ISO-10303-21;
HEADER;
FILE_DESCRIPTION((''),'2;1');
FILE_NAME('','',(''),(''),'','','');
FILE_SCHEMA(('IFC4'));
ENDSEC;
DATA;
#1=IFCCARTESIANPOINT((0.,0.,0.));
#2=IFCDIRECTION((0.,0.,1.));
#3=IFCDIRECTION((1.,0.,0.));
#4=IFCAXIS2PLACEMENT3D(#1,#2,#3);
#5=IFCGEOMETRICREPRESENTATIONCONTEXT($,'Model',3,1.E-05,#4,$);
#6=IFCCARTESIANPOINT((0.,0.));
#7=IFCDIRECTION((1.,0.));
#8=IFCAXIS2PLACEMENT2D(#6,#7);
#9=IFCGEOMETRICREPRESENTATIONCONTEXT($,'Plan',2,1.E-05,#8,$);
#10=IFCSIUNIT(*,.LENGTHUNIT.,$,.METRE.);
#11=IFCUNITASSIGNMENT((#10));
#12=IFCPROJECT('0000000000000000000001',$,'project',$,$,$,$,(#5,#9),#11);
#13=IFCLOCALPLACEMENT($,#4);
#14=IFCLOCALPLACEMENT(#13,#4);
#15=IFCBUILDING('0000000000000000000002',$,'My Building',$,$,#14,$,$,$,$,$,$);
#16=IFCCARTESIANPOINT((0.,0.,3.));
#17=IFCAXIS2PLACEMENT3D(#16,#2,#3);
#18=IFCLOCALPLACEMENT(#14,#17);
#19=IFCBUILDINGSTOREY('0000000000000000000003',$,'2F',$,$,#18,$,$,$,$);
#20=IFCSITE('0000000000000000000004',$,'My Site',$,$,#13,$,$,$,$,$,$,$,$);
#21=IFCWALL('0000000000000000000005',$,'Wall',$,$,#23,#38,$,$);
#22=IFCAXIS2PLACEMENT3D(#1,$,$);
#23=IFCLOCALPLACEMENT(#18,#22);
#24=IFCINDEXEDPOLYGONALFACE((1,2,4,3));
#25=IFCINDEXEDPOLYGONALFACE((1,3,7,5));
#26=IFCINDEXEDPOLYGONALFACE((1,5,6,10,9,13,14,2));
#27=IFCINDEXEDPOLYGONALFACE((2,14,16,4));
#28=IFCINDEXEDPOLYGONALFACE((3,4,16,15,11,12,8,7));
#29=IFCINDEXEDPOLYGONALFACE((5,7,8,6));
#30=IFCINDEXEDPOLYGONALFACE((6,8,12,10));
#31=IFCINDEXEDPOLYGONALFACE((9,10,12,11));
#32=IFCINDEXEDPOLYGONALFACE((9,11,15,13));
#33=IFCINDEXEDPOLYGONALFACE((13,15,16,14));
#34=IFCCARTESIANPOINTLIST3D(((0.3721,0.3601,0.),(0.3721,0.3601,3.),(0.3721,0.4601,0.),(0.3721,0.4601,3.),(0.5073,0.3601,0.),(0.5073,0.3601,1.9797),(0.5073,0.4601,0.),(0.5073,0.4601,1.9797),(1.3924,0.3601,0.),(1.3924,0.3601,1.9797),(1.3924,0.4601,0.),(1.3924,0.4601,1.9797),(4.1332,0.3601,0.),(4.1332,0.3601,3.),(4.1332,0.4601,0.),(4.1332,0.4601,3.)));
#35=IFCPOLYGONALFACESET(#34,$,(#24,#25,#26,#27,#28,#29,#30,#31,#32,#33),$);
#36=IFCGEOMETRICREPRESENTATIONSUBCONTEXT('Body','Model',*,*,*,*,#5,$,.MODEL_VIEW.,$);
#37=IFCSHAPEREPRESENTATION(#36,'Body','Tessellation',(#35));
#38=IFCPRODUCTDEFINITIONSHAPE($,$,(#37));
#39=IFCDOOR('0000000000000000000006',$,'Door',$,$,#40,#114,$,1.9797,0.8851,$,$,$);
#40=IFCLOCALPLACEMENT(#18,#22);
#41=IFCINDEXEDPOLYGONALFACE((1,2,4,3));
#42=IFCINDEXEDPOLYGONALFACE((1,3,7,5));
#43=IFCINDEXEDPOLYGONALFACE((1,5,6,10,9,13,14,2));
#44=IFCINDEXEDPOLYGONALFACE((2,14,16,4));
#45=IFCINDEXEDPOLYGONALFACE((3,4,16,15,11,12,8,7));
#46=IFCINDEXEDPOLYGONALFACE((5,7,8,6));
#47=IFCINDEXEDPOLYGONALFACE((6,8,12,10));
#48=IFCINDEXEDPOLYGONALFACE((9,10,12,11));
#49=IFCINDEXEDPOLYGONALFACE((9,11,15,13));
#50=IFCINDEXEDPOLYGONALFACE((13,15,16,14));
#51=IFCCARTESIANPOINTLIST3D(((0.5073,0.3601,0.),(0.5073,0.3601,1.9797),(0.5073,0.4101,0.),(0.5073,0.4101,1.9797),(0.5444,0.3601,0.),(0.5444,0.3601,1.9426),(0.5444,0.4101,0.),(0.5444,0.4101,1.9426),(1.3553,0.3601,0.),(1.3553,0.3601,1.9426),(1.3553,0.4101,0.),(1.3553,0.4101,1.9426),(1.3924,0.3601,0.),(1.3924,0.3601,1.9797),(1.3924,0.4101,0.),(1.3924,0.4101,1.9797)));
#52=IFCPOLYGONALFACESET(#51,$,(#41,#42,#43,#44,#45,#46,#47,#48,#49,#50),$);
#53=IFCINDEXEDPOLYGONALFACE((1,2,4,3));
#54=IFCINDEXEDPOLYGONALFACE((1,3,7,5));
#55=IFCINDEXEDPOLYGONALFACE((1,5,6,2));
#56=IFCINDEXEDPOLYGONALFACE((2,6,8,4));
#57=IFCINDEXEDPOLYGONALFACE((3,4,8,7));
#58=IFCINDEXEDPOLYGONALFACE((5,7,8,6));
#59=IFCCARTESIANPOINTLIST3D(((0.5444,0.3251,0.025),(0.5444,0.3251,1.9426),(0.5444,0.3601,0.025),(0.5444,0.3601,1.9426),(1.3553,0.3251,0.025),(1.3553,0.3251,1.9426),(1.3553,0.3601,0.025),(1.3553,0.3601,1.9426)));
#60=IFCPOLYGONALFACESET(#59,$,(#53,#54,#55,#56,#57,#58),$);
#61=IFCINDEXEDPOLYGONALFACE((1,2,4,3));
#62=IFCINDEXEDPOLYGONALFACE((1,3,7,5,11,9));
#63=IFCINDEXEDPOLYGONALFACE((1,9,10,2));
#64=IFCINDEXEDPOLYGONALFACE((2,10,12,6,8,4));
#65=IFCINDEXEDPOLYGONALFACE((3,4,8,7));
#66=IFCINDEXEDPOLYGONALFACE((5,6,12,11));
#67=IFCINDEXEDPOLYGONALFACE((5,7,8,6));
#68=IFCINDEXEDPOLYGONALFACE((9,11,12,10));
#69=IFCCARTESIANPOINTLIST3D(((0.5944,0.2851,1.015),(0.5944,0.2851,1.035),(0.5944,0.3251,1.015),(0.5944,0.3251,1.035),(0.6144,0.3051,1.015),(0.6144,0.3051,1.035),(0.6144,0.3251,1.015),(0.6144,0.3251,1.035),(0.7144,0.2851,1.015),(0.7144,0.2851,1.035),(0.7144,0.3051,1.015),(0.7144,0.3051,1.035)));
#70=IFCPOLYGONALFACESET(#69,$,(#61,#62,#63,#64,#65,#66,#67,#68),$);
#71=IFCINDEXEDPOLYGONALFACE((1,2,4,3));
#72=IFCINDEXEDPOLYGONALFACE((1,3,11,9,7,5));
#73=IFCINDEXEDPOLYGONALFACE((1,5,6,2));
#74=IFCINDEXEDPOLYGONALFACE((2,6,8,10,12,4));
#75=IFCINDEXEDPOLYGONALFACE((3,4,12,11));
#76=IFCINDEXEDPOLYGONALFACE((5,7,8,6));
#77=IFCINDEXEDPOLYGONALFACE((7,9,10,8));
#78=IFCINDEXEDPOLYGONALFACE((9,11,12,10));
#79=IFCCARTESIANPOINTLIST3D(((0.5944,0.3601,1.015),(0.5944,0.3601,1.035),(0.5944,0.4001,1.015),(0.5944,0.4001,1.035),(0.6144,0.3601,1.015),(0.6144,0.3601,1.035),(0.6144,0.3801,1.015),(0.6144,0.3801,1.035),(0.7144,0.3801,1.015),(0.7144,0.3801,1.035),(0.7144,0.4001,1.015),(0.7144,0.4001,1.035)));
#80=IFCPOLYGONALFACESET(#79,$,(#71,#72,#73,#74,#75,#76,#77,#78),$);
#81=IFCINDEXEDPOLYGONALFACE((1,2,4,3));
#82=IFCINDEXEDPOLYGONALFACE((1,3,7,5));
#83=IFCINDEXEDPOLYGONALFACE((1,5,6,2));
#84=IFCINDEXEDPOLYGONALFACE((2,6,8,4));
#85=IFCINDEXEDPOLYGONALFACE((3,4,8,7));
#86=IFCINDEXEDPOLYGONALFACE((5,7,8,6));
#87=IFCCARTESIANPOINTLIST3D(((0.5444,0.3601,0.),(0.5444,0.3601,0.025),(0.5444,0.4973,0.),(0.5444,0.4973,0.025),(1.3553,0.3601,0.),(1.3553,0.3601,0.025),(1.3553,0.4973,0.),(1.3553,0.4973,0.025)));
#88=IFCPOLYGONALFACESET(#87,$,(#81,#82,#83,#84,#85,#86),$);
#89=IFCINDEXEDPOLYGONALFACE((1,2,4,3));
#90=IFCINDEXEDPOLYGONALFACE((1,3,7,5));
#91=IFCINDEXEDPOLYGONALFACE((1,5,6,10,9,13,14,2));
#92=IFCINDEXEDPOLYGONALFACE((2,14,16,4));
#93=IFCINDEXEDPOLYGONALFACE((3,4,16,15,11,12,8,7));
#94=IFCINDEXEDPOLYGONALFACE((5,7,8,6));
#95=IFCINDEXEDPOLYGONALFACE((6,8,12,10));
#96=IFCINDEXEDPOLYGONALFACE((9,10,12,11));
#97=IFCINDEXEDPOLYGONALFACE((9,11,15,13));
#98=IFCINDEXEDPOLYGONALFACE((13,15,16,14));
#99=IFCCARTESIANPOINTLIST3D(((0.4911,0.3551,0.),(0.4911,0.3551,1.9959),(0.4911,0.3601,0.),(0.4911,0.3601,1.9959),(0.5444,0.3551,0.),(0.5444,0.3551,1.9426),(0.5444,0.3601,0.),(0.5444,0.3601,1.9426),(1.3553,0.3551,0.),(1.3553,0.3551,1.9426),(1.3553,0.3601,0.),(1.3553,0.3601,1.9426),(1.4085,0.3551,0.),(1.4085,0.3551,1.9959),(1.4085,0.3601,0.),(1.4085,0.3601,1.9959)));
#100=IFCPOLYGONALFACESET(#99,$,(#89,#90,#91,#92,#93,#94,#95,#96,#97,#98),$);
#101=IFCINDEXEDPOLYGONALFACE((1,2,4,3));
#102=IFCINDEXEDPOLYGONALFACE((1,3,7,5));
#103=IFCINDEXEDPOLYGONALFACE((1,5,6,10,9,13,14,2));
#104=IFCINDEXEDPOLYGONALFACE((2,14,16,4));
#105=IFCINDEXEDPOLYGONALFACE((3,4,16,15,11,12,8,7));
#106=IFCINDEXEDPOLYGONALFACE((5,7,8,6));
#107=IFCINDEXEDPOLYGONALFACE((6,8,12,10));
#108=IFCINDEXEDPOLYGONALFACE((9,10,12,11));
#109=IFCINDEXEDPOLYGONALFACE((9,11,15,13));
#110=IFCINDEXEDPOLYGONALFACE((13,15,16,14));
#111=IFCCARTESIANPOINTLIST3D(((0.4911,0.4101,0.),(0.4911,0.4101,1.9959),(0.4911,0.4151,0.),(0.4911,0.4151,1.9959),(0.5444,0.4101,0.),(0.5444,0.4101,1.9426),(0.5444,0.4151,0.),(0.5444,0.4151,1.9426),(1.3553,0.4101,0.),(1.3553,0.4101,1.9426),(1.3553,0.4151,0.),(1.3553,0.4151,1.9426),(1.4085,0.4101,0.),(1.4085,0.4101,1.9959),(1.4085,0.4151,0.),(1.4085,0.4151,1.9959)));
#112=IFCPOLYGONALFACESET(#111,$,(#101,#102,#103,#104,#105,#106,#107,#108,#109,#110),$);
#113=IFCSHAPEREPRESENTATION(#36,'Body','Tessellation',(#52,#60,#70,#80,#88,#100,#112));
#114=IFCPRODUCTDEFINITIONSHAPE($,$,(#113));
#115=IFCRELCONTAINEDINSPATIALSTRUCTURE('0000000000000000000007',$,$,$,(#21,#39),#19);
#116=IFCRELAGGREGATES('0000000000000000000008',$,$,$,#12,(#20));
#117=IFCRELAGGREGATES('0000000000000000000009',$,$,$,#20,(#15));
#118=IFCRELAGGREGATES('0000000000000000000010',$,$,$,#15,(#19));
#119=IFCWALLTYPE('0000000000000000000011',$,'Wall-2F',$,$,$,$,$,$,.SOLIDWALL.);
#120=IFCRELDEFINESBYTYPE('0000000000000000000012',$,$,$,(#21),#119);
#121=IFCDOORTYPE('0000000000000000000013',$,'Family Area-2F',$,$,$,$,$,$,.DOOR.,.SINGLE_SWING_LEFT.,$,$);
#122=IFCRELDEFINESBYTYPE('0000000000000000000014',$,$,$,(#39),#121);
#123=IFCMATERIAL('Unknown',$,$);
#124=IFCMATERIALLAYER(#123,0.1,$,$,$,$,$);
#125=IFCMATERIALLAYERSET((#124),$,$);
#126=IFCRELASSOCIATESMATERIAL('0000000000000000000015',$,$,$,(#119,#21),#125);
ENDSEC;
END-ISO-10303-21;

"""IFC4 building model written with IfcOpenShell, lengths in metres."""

from ifc_helpers import new_model, entity, si_unit, frame, origin_with_axes, origin_2d_with_axis, place, context, subcontext, project, spatial, line, indexed_curve, outline, extrude, shape, source, transform, mapped, material, layer, layer_set, layer_usage, type_object, type_shapes, element, fill, save


model = new_model("IFC4")

# Units and contexts
model_context = context("Model", 3, precision=1e-05, world=origin_with_axes())
plan_context = context("Plan", 2, precision=1e-05, world=origin_2d_with_axis())
body_context_1 = subcontext(model_context, "Body", "Model", "MODEL_VIEW")
body_context_2 = subcontext(plan_context, "Body", "Plan", "PLAN_VIEW")
ifc_project = project(units=[si_unit("LENGTHUNIT", "METRE")], contexts=[model_context, plan_context])

# Site, building, storey
site_placement = place(None, origin_with_axes())
site = spatial("IfcSite", under=ifc_project, at=site_placement, Name="My Site")
building_placement = place(site_placement, origin_with_axes())
building = spatial("IfcBuilding", under=site, at=building_placement, Name="My Building")
storey_placement = place(building_placement, frame((0.0, 0.0, 3.0), z_axis=(0.0, 0.0, 1.0), x_axis=(1.0, 0.0, 0.0)))
storey = spatial("IfcBuildingStorey", under=building, at=storey_placement, Name="2F")

# Shared definitions
ifc_material = material(Name="Unknown")

# Shared definitions
ifc_layer_1 = layer(ifc_material, 0.1)
ifc_layer_set_1 = layer_set([ifc_layer_1])
wall_type = type_object("IfcWallType", Name="Wall-2F", PredefinedType="SOLIDWALL", material=ifc_layer_set_1)

# Wall, opening, door
ifc_layer_usage_1 = layer_usage(ifc_layer_set_1, "AXIS2", "POSITIVE", 0.0)
wall_1_placement = place(storey_placement, frame((4.1332, 0.4601, 0.0), z_axis=(0.0, 0.0, 1.0), x_axis=(-1.0, 0.0, 0.0)))
wall_1 = element("IfcWall", 1, at=wall_1_placement, inside=storey, type_object=wall_type, material=ifc_layer_usage_1, Name="Wall", context=body_context_1, shape_type="SweptSolid", body=[
    extrude(outline(indexed_curve([(0.0, 0.0), (0.0, 0.1), (3.7611, 0.1), (3.7611, 0.0)], segments=[line(1, 2, 3, 4, 1)])), origin_with_axes(), (0.0, 0.0, 1.0), 3.0),
])
shared_shape_1 = source(origin_with_axes(), body_context_1, "Body", "SweptSolid", [
    extrude(outline(indexed_curve([(0.0, 0.0), (0.8851, 0.0), (0.8851, 1.9797), (0.0, 1.9797)], segments=[line(1, 2, 3, 4, 1)])), frame((0.0, -0.6, 0.0), z_axis=(0.0, -1.0, 0.0), x_axis=(1.0, 0.0, 0.0)), (0.0, 0.0, -1.0), 1.2),
])
opening_1_placement = place(wall_1_placement, frame((3.6259, 0.1, 0.0), z_axis=(0.0, 0.0, 1.0), x_axis=(-1.0, 0.0, 0.0)))
opening_1 = element("IfcOpeningElement", 2, at=opening_1_placement, cuts=wall_1, PredefinedType="OPENING", context=body_context_1, shape_type="MappedRepresentation", body=[
    mapped(shared_shape_1, transform((0.0, 0.0, 0.0), x_axis=(1.0, 0.0, 0.0), y_axis=(0.0, 1.0, 0.0), z_axis=(0.0, 0.0, 1.0), scale=1.0)),
])
door_type_1 = type_object("IfcDoorType", Name="Family Area-2F", OperationType="SINGLE_SWING_LEFT", PredefinedType="DOOR")
shared_shape_2 = source(origin_with_axes(), body_context_1, "Body", "SweptSolid", [
    extrude(outline(indexed_curve([(0.0, 0.0), (0.0, 1.9797), (0.8851, 1.9797), (0.8851, 0.0), (0.848, 0.0), (0.848, 1.9426), (0.0371, 1.9426), (0.0371, 0.0)], segments=[line(1, 2, 3, 4, 5, 6, 7, 8, 1)])), frame((0.0, 0.0, 0.0), z_axis=(0.0, -1.0, 0.0), x_axis=(1.0, 0.0, 0.0)), (0.0, 0.0, -1.0), 0.05),
    extrude(outline(indexed_curve([(0.0, 0.0), (0.8109, 0.0), (0.8109, 0.035), (0.0, 0.035)], segments=[line(1, 2, 3, 4, 1)])), frame((0.0371, -0.035, 0.025), z_axis=(0.0, 0.0, 1.0), x_axis=(1.0, 0.0, 0.0)), (0.0, 0.0, 1.0), 1.9176),
    extrude(outline(indexed_curve([(0.0, 0.0), (0.0, -0.04), (0.12, -0.04), (0.12, -0.02), (0.02, -0.02), (0.02, 0.0)], segments=[line(1, 2, 3, 4, 5, 6, 1)])), frame((0.0871, -0.035, 1.015), z_axis=(0.0, 0.0, 1.0), x_axis=(1.0, 0.0, 0.0)), (0.0, 0.0, 1.0), 0.02),
    extrude(outline(indexed_curve([(0.0, 0.0), (0.0, 0.04), (0.12, 0.04), (0.12, 0.02), (0.02, 0.02), (0.02, 0.0)], segments=[line(1, 2, 3, 4, 5, 6, 1)])), frame((0.0871, 0.0, 1.015), z_axis=(0.0, 0.0, 1.0), x_axis=(1.0, 0.0, 0.0)), (0.0, 0.0, 1.0), 0.02),
    extrude(outline(indexed_curve([(0.0, 0.0), (0.8109, 0.0), (0.8109, 0.1372), (0.0, 0.1372)], segments=[line(1, 2, 3, 4, 1)])), frame((0.0371, 0.0, 0.0), z_axis=(0.0, 0.0, 1.0), x_axis=(1.0, 0.0, 0.0)), (0.0, 0.0, 1.0), 0.025),
    extrude(outline(indexed_curve([(0.0, 0.0), (0.0, 1.9959), (0.9174, 1.9959), (0.9174, 0.0), (0.8641, 0.0), (0.8641, 1.9426), (0.0532, 1.9426), (0.0532, 0.0)], segments=[line(1, 2, 3, 4, 5, 6, 7, 8, 1)])), frame((-0.0162, -0.005, 0.0), z_axis=(0.0, -1.0, 0.0), x_axis=(1.0, 0.0, 0.0)), (0.0, 0.0, -1.0), 0.005),
    extrude(outline(indexed_curve([(0.0, 0.0), (0.0, 1.9959), (0.9174, 1.9959), (0.9174, 0.0), (0.8641, 0.0), (0.8641, 1.9426), (0.0532, 1.9426), (0.0532, 0.0)], segments=[line(1, 2, 3, 4, 5, 6, 7, 8, 1)])), frame((-0.0162, 0.05, 0.0), z_axis=(0.0, -1.0, 0.0), x_axis=(1.0, 0.0, 0.0)), (0.0, 0.0, -1.0), 0.005),
])
shared_shape_3 = source(origin_with_axes(), body_context_2, "Body", "Curve2D", [
    entity("IfcIndexedPolyCurve", entity("IfcCartesianPointList2D", [[0.0, 0.0], [0.0371, 0.0], [0.0371, 0.05], [0.0, 0.05]]), [entity("IfcLineIndex", [1, 2, 3, 4, 1])]),
    entity("IfcIndexedPolyCurve", entity("IfcCartesianPointList2D", [[0.8851, 0.0], [0.848, 0.0], [0.848, 0.05], [0.8851, 0.05]]), [entity("IfcLineIndex", [1, 2, 3, 4, 1])]),
    entity("IfcIndexedPolyCurve", entity("IfcCartesianPointList2D", [[1.2534, -0.035], [0.4425, -0.035], [0.4425, 0.0], [1.2534, 0.0]]), [entity("IfcLineIndex", [1, 2, 3, 4, 1])]),
])
type_shapes(door_type_1, [shared_shape_2, shared_shape_3])
door_1_placement = place(opening_1_placement, frame((0.0, 0.0, 0.0), z_axis=(0.0, 0.0, 1.0), x_axis=(1.0, 0.0, 0.0)))
door_1 = element("IfcDoor", 3, at=door_1_placement, inside=storey, type_object=door_type_1, Name="Door", OverallHeight=1.9797, OverallWidth=0.8851, shapes=[
    shape(body_context_1, "Body", "MappedRepresentation", [mapped(shared_shape_2, transform((0.0, 0.0, 0.0), x_axis=(1.0, 0.0, 0.0), y_axis=(0.0, 1.0, 0.0), z_axis=(0.0, 0.0, 1.0), scale=1.0))]),
    shape(body_context_2, "Body", "MappedRepresentation", [mapped(shared_shape_3, transform((0.0, 0.0, 0.0), x_axis=(1.0, 0.0, 0.0), y_axis=(0.0, 1.0, 0.0), z_axis=(0.0, 0.0, 1.0), scale=1.0))]),
])
fill(opening_1, door_1)

save(model, "model.ifc")
